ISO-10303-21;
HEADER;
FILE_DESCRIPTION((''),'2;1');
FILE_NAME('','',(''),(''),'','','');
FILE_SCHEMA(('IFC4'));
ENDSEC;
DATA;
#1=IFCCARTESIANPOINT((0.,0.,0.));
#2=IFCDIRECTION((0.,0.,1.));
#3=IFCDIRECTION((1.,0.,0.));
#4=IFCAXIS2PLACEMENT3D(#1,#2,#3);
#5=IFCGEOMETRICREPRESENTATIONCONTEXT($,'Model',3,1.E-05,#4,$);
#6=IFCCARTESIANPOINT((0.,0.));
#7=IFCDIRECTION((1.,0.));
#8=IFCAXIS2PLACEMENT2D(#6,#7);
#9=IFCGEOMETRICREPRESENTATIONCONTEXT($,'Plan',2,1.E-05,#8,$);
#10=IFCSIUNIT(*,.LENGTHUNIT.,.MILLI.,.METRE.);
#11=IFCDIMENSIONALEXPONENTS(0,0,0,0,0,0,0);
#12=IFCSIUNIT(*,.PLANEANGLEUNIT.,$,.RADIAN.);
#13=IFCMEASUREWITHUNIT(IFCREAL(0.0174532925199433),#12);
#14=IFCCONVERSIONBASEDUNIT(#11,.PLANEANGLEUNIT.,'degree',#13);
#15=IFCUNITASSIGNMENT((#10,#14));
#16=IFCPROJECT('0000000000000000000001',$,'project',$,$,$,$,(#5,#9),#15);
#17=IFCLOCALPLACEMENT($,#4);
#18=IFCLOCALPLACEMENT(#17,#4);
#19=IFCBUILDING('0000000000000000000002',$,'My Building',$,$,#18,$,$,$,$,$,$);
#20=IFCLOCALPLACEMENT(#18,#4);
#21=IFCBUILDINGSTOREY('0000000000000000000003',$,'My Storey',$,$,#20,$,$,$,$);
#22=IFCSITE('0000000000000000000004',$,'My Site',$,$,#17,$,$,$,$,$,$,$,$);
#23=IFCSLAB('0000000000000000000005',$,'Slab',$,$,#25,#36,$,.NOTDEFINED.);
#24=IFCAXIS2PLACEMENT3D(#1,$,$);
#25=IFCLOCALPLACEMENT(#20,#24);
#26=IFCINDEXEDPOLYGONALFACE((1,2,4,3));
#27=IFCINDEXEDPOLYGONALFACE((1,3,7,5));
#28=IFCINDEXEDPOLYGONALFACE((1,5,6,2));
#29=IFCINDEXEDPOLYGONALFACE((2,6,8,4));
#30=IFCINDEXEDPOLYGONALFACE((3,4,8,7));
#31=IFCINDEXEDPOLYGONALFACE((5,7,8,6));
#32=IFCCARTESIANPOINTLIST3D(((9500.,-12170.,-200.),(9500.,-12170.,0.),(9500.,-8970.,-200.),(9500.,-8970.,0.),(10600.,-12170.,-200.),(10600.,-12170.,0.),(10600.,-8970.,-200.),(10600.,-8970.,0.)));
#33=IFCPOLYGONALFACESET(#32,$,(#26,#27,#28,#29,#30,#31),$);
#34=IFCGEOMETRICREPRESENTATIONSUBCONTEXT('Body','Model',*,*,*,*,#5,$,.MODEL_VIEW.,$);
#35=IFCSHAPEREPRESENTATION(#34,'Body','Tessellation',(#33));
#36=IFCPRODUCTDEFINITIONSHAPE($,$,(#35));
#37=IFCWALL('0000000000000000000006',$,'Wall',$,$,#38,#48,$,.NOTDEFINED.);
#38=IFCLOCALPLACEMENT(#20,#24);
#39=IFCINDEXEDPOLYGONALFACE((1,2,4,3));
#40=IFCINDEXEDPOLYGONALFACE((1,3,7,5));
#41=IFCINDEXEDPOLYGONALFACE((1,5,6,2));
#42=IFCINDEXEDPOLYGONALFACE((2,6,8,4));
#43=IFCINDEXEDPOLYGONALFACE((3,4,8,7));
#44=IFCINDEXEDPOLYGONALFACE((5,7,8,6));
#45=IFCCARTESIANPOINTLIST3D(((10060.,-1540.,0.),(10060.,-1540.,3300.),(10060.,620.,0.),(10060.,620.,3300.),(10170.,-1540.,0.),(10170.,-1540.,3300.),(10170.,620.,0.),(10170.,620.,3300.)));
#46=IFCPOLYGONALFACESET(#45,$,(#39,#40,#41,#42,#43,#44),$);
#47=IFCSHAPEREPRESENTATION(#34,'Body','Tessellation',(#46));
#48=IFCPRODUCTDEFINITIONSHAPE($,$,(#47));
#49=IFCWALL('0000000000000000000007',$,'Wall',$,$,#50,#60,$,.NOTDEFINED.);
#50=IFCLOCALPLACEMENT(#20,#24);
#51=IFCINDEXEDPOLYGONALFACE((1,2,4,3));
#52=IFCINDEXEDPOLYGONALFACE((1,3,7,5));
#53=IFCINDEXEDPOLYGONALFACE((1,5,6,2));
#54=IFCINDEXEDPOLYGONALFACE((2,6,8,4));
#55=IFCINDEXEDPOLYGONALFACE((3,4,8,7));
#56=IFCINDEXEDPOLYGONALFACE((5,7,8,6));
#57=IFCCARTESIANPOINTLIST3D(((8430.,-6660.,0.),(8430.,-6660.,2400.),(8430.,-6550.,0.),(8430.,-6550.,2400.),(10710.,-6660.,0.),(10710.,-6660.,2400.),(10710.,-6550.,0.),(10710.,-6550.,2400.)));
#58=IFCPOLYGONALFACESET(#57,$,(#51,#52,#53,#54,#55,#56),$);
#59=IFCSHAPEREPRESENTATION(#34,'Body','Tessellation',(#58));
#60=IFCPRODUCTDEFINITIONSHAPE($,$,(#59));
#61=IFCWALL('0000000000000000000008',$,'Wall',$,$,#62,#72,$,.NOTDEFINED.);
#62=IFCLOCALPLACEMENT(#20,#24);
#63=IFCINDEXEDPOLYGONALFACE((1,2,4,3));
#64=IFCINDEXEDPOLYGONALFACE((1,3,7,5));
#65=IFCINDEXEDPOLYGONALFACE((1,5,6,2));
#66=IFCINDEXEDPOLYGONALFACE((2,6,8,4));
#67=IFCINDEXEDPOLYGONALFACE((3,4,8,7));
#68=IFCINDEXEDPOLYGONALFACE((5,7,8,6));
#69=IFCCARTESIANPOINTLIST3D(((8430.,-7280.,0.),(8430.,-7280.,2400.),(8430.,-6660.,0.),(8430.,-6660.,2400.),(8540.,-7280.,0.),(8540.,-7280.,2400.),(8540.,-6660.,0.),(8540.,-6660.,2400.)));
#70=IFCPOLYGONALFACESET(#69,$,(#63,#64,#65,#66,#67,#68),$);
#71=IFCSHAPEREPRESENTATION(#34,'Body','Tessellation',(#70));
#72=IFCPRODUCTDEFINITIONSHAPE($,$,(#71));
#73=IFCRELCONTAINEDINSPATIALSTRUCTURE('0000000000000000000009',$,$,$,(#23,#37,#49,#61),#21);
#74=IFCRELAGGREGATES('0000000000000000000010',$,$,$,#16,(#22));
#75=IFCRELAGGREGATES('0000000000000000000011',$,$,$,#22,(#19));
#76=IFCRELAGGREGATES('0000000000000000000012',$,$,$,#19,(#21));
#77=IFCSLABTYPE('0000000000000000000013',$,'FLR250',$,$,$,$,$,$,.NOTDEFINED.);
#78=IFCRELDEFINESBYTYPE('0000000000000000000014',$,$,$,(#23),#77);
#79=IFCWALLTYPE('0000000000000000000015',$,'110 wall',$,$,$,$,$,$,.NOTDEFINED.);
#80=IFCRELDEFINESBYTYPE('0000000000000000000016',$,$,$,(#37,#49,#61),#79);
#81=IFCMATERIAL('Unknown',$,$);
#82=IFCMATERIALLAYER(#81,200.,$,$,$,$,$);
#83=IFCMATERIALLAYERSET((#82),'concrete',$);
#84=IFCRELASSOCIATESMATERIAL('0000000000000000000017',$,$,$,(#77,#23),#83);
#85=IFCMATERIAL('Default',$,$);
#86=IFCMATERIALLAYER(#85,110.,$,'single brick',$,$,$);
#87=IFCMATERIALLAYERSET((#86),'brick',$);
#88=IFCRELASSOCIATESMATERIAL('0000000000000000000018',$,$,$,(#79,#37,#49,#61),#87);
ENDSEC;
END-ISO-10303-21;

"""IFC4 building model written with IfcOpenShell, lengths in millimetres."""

from ifc_helpers import new_model, entity, si_unit, converted_unit, frame, origin_with_axes, origin_2d_with_axis, place, context, subcontext, project, spatial, line, indexed_curve, outline, extrude, material, layer, layer_set, layer_usage, type_object, element, save


model = new_model("IFC4")

# Units and contexts
model_context = context("Model", 3, precision=1e-05, world=origin_with_axes())
plan_context = context("Plan", 2, precision=1e-05, world=origin_2d_with_axis())
body_context_1 = subcontext(model_context, "Body", "Model", "MODEL_VIEW")
ifc_project = project(units=[si_unit("LENGTHUNIT", "METRE", prefix="MILLI"), converted_unit("PLANEANGLEUNIT", "degree", entity("IfcReal", 0.0174532925199433), si_unit("PLANEANGLEUNIT", "RADIAN"), dimensions=[0, 0, 0, 0, 0, 0, 0])], contexts=[model_context, plan_context])

# Site, building, storey
site_placement = place(None, origin_with_axes())
site = spatial("IfcSite", under=ifc_project, at=site_placement, Name="My Site")
building_placement = place(site_placement, origin_with_axes())
building = spatial("IfcBuilding", under=site, at=building_placement, Name="My Building")
storey_placement = place(building_placement, origin_with_axes())
storey = spatial("IfcBuildingStorey", under=building, at=storey_placement, Name="My Storey")

# Slab
ifc_material_1 = material(Name="Unknown")
ifc_layer_1 = layer(ifc_material_1, 200.0)
ifc_layer_set_1 = layer_set([ifc_layer_1], Name="concrete")
slab_type = type_object("IfcSlabType", Name="FLR250", PredefinedType="NOTDEFINED", material=ifc_layer_set_1)
ifc_layer_usage_1 = layer_usage(ifc_layer_set_1, "AXIS3", "POSITIVE", 0.0)
slab_1_placement = place(storey_placement, frame((9500.0, -10570.0, -200.0), z_axis=(0.0, 0.0, 1.0), x_axis=(1.0, 0.0, 0.0)))
element("IfcSlab", 1, at=slab_1_placement, inside=storey, type_object=slab_type, material=ifc_layer_usage_1, Name="Slab", PredefinedType="NOTDEFINED", context=body_context_1, shape_type="SweptSolid", body=[
    extrude(outline(indexed_curve([(0.0, -1600.0), (1100.0, -1600.0), (1100.0, 1600.0), (0.0, 1600.0)], segments=[line(3, 2), line(2, 1), line(1, 4), line(4, 3)], self_intersect=False)), None, (0.0, 0.0, 1.0), 200.0),
])

# Walls
ifc_material_2 = material(Name="Default")
ifc_layer_2 = layer(ifc_material_2, 110.0, Name="single brick")
ifc_layer_set_2 = layer_set([ifc_layer_2], Name="brick")
ifc_layer_usage_2 = layer_usage(ifc_layer_set_2, "AXIS2", "POSITIVE", 0.0)
wall_type_1 = type_object("IfcWallType", Name="110 wall", PredefinedType="NOTDEFINED", material=ifc_layer_set_2)
wall_1_placement = place(storey_placement, frame((10060.0, 620.0, 0.0), z_axis=(0.0, 0.0, 1.0), x_axis=(-0.000001, -1.0, 0.0)))
element("IfcWall", 2, at=wall_1_placement, inside=storey, type_object=wall_type_1, material=ifc_layer_usage_2, Name="Wall", PredefinedType="NOTDEFINED", context=body_context_1, shape_type="SweptSolid", body=[
    extrude(outline(indexed_curve([(0.0, 0.0), (0.0, 110.0), (2160.0, 110.0), (2160.0, 0.0), (0.0, 0.0)], self_intersect=False)), origin_with_axes(), (0.0, 0.0, 1.0), 3300.0),
])
ifc_layer_usage_3 = layer_usage(ifc_layer_set_2, "AXIS2", "POSITIVE", 0.0)
wall_2_placement = place(storey_placement, frame((10710.0, -6550.0, 0.0), z_axis=(0.0, 0.0, 1.0), x_axis=(-1.0, 0.0, 0.0)))
element("IfcWall", 3, at=wall_2_placement, inside=storey, type_object=wall_type_1, material=ifc_layer_usage_3, Name="Wall", PredefinedType="NOTDEFINED", context=body_context_1, shape_type="SweptSolid", body=[
    extrude(outline(indexed_curve([(0.0, 0.0), (0.0, 110.0), (2280.0, 110.0), (2280.0, 0.0), (0.0, 0.0)], self_intersect=False)), origin_with_axes(), (0.0, 0.0, 1.0), 2400.0),
])
ifc_layer_usage_4 = layer_usage(ifc_layer_set_2, "AXIS2", "POSITIVE", 0.0)
wall_3_placement = place(storey_placement, frame((8540.0, -7280.0, 0.0), z_axis=(0.0, 0.0, 1.0), x_axis=(0.000001, 1.0, 0.0)))
element("IfcWall", 4, at=wall_3_placement, inside=storey, type_object=wall_type_1, material=ifc_layer_usage_4, Name="Wall", PredefinedType="NOTDEFINED", context=body_context_1, shape_type="SweptSolid", body=[
    extrude(outline(indexed_curve([(0.0, 0.0), (0.0, 110.0), (620.0, 110.0), (620.0, 0.0), (0.0, 0.0)], self_intersect=False)), origin_with_axes(), (0.0, 0.0, 1.0), 2400.0),
])

save(model, "model.ifc")
